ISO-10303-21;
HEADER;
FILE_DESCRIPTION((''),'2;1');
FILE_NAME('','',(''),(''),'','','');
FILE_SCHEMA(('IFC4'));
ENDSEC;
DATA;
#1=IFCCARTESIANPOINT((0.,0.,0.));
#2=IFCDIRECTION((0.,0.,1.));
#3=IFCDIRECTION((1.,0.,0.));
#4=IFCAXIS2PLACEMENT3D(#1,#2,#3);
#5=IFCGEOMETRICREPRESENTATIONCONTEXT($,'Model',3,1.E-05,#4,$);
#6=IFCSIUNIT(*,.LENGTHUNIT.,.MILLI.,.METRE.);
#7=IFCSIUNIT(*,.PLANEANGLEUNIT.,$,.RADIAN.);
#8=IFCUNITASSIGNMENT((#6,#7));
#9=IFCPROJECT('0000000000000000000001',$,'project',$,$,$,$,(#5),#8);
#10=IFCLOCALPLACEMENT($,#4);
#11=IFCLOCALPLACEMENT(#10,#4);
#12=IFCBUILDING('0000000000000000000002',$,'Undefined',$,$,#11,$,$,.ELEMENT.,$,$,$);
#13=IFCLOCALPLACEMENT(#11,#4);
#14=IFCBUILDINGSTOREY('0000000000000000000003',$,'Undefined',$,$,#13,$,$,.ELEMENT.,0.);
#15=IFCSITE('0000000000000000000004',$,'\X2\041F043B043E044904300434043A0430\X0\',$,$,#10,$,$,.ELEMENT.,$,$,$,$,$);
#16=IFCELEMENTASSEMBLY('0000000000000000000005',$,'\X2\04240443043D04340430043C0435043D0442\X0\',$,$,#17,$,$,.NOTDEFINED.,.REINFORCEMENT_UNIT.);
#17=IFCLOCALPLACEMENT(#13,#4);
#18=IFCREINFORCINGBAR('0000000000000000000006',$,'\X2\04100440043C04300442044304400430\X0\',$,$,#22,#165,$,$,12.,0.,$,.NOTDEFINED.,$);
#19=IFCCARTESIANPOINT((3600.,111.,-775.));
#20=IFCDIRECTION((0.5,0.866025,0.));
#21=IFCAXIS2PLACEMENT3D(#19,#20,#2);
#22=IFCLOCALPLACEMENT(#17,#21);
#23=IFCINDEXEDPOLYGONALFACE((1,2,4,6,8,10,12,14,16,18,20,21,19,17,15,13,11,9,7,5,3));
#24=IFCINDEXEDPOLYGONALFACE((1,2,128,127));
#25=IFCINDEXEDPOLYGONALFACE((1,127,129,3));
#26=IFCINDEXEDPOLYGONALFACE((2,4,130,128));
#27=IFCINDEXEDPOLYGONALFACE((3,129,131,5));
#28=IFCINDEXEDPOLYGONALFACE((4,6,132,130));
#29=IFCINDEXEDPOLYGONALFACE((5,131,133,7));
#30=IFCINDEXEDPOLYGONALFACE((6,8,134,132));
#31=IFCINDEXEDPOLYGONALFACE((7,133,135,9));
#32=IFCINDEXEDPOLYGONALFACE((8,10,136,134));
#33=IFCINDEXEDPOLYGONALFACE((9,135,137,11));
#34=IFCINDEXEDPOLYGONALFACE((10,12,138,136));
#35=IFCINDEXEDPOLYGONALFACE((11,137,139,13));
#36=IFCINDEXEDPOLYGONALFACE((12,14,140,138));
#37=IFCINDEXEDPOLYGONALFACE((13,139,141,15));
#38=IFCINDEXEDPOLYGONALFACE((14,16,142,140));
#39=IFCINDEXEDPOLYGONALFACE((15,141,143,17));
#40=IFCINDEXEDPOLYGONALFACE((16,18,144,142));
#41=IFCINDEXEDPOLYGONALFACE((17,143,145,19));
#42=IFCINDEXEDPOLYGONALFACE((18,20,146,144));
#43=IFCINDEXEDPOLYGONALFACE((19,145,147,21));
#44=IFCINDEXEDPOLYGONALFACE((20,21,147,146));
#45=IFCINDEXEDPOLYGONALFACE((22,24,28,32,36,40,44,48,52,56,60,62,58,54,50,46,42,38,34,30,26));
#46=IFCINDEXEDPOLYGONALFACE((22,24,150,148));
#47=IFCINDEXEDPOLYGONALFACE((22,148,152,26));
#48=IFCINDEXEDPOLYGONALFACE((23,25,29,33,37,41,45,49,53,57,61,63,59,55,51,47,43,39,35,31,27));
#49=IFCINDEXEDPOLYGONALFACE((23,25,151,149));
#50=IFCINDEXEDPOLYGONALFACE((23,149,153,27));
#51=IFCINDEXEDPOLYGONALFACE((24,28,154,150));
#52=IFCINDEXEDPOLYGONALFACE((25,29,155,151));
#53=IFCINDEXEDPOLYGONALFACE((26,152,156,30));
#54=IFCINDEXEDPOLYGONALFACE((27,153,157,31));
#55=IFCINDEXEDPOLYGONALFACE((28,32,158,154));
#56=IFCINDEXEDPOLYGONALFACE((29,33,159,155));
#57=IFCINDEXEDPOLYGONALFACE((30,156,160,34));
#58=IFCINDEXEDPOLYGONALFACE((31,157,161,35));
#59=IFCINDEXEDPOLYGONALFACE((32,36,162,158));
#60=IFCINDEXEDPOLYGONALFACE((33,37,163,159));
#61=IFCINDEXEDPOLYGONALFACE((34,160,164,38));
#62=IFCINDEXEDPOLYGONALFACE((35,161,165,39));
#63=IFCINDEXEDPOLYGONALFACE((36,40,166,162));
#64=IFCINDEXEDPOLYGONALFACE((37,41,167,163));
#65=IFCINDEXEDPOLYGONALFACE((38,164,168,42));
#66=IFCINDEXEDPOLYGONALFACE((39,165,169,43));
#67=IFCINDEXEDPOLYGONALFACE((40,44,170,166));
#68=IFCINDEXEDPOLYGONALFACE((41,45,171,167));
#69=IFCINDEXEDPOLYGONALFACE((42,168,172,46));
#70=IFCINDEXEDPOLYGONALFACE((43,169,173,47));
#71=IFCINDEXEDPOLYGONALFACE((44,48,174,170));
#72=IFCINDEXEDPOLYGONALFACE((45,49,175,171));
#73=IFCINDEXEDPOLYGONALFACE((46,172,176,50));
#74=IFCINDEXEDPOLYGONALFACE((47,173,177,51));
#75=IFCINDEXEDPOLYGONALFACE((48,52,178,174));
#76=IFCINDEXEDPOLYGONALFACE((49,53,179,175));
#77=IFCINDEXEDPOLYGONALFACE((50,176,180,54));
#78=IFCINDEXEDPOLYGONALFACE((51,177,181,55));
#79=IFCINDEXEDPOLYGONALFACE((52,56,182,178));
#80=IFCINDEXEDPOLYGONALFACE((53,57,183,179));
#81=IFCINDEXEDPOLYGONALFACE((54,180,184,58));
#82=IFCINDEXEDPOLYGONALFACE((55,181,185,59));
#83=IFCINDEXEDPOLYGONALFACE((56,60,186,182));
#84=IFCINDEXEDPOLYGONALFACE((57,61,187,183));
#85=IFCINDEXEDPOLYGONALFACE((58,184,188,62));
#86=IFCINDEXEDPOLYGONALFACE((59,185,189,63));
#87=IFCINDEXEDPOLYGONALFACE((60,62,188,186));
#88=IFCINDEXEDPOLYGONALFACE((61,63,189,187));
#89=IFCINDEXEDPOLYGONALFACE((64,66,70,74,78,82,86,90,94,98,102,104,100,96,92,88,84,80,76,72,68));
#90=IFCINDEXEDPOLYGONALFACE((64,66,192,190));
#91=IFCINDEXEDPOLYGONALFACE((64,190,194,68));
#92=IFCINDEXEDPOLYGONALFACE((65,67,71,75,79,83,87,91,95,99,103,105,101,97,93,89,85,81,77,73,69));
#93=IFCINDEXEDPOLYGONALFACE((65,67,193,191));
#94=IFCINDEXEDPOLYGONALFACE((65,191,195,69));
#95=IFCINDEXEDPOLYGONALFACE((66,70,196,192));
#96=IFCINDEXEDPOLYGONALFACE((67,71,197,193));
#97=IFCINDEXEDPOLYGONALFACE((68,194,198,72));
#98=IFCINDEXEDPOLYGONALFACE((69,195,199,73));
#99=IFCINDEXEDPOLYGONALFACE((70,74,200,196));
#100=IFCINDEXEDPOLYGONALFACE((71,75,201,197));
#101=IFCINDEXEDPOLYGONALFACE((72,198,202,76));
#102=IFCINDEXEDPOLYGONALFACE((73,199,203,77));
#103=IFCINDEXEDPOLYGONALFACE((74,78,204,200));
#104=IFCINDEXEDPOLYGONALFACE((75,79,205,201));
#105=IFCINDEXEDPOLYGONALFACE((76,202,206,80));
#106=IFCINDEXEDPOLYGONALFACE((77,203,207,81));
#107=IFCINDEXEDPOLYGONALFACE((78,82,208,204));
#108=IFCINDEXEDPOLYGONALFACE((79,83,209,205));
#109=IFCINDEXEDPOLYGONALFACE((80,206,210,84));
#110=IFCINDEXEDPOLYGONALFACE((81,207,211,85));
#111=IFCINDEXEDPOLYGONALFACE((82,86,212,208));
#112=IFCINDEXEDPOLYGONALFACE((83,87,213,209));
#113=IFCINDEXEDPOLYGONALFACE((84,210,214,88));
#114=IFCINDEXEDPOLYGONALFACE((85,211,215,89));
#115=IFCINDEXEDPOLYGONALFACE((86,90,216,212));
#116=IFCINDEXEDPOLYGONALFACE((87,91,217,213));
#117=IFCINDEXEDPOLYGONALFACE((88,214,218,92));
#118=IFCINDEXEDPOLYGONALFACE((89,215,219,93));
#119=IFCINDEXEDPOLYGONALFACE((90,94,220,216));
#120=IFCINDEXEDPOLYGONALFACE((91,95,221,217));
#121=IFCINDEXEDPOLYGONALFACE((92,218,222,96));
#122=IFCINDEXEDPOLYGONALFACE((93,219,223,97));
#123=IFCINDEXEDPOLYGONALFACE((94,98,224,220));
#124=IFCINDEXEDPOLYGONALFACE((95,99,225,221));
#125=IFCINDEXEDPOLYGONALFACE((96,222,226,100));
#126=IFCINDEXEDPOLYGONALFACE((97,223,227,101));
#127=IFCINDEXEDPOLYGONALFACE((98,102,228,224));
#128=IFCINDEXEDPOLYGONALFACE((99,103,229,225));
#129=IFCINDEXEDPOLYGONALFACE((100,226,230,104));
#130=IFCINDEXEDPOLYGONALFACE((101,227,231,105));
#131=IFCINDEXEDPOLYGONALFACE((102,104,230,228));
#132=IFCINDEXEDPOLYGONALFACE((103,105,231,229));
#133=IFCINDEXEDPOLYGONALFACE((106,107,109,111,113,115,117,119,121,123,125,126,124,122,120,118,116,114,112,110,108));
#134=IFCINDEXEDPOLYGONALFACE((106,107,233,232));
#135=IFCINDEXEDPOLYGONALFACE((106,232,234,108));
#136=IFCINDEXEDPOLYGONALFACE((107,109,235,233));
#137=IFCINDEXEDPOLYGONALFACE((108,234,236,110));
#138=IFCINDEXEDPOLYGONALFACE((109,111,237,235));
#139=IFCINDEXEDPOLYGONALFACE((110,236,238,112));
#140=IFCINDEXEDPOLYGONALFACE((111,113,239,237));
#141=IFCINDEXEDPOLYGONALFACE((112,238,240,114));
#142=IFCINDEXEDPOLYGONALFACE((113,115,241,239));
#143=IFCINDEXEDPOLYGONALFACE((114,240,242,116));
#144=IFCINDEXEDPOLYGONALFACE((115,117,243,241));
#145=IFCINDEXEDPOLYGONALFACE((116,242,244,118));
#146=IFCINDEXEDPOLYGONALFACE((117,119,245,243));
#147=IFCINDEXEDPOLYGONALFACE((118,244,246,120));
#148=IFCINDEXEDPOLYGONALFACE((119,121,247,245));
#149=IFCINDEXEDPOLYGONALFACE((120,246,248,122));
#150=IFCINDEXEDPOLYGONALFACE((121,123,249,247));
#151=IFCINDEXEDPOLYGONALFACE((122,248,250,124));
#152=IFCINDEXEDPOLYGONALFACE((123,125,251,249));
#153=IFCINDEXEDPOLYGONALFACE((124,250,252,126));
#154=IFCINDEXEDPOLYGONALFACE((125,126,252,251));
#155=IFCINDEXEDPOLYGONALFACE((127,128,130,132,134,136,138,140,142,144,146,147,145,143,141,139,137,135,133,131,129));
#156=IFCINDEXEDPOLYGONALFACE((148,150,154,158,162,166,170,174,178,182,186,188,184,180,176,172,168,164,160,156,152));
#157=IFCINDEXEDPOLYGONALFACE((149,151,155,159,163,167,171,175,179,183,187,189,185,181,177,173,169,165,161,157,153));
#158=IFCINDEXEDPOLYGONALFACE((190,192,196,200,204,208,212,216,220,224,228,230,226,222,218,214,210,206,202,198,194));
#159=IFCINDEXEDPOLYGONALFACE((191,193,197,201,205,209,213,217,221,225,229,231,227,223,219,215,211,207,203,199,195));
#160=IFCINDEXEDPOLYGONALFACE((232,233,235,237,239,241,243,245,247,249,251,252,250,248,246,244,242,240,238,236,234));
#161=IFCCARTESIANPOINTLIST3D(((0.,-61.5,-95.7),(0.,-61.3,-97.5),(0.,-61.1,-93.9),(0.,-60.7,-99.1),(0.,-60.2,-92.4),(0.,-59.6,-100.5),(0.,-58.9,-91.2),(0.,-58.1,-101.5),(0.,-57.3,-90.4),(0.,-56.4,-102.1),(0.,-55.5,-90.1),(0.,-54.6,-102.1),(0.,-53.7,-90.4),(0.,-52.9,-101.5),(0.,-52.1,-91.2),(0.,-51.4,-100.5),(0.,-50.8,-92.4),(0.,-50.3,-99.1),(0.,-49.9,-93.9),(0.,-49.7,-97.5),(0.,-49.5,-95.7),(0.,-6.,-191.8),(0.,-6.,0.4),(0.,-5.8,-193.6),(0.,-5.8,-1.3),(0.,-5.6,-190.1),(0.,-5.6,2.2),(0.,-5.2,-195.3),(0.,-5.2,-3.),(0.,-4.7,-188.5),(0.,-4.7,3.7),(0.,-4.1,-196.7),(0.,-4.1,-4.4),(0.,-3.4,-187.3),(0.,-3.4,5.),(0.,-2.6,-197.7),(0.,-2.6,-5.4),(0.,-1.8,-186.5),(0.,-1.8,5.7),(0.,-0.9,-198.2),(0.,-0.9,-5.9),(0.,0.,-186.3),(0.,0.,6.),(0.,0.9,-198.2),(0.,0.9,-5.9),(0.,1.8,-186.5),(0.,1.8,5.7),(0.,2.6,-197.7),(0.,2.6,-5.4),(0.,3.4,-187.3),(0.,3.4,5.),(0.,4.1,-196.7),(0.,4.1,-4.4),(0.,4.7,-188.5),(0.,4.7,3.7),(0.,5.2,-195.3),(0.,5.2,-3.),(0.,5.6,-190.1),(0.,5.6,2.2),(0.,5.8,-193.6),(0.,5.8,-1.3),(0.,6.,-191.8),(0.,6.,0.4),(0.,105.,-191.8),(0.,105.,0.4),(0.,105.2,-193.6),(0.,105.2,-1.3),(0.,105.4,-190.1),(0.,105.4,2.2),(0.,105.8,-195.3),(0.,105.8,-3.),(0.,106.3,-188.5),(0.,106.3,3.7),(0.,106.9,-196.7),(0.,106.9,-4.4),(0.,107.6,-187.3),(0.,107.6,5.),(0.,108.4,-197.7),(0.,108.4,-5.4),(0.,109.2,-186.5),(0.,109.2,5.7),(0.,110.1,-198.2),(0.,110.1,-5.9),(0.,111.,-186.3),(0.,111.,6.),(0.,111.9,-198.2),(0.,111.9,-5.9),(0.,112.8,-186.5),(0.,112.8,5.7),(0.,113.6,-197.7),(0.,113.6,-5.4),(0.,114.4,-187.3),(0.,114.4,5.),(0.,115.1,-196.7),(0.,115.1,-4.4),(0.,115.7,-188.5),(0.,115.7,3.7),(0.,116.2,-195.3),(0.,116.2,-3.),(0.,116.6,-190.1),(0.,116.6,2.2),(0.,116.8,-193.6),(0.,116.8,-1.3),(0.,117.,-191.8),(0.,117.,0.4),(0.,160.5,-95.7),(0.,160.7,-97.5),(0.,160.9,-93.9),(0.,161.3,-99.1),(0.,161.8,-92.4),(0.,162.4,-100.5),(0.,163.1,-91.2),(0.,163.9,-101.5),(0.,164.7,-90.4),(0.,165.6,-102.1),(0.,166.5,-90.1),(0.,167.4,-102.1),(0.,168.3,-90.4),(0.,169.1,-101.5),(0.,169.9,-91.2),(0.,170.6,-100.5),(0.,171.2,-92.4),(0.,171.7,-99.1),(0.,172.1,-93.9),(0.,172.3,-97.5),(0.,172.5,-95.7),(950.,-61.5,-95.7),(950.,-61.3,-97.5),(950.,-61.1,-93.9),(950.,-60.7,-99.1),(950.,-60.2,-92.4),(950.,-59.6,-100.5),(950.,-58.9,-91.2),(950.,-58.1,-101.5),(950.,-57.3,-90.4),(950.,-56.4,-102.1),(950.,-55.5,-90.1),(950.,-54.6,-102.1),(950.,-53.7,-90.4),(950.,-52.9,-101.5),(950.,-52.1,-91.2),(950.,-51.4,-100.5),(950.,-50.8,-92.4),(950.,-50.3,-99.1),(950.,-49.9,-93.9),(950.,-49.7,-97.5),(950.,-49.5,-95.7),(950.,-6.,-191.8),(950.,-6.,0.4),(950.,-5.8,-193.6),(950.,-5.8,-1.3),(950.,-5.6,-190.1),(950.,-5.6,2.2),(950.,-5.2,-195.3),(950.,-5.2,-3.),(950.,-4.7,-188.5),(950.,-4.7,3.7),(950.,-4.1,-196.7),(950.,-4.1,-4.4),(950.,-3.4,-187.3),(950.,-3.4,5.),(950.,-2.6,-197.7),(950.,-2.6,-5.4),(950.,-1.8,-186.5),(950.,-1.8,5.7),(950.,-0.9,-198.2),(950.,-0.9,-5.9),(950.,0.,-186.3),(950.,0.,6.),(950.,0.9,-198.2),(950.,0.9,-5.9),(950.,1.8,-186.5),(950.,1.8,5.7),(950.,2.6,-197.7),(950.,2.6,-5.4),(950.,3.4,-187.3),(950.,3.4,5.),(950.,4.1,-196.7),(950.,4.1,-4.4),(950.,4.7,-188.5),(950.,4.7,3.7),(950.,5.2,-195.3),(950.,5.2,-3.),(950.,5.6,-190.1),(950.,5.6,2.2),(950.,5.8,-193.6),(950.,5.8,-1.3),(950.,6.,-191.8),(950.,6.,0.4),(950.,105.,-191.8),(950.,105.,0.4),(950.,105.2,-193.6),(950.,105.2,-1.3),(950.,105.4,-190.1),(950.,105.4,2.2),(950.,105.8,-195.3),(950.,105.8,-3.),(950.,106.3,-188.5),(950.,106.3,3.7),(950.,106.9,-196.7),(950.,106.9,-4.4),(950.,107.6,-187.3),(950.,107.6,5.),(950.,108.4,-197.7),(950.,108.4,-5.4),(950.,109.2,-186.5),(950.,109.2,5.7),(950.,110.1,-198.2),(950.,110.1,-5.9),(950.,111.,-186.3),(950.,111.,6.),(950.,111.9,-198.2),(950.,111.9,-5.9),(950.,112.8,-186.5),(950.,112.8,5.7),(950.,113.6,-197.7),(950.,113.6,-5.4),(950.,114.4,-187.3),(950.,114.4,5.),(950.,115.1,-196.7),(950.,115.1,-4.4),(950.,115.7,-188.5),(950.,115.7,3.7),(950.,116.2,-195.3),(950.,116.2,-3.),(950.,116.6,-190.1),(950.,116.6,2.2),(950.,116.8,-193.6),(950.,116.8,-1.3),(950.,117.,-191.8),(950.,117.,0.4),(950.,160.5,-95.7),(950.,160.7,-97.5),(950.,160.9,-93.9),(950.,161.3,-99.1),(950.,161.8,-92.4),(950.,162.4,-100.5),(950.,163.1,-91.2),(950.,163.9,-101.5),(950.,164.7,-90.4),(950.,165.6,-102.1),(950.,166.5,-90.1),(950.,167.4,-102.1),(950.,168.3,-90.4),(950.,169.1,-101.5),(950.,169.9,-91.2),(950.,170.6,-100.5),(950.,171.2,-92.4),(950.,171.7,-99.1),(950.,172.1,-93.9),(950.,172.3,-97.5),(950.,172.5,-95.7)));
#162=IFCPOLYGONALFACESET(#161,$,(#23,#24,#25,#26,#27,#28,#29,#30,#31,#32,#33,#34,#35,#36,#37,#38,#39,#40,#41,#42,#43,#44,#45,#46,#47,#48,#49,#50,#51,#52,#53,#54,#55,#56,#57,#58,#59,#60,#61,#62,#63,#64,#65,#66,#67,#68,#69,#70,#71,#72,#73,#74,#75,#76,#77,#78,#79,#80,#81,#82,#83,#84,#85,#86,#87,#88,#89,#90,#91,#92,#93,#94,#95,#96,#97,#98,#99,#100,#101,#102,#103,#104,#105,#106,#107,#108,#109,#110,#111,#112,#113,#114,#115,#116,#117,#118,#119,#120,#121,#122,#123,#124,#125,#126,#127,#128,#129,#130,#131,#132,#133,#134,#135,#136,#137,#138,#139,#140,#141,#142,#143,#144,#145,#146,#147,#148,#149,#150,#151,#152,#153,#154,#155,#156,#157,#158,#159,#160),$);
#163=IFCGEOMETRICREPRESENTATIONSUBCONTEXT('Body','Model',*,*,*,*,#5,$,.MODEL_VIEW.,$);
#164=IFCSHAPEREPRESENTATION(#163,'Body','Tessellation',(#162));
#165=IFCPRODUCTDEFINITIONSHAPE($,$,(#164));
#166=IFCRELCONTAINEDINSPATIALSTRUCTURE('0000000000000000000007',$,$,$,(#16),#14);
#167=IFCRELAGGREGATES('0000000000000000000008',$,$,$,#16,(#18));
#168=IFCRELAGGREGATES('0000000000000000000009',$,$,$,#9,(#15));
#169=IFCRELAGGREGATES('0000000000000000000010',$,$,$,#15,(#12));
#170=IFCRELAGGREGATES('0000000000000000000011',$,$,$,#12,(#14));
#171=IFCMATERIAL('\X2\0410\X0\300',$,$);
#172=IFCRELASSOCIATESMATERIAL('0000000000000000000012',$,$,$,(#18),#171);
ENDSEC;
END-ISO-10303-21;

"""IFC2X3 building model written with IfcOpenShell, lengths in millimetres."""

from ifc_helpers import new_model, entity, si_unit, frame, origin_with_axes, place, context, subcontext, project, spatial, source, transform, mapped, material, element, aggregate, save


model = new_model("IFC2X3")

# Units and contexts
model_context = context("Model", 3, precision=1e-05, world=origin_with_axes())
body_context = subcontext(model_context, "Body", "Model", "MODEL_VIEW")
ifc_project = project(units=[si_unit("LENGTHUNIT", "METRE", prefix="MILLI"), si_unit("PLANEANGLEUNIT", "RADIAN")], contexts=[model_context])

# Site, building, storey
site_placement = place(None, origin_with_axes())
site = spatial("IfcSite", under=ifc_project, at=site_placement, Name="Площадка", CompositionType="ELEMENT")
building_placement = place(site_placement, origin_with_axes())
building = spatial("IfcBuilding", under=site, at=building_placement, Name="Undefined", CompositionType="ELEMENT")
storey_placement = place(building_placement, origin_with_axes())
storey = spatial("IfcBuildingStorey", under=building, at=storey_placement, Name="Undefined", CompositionType="ELEMENT", Elevation=0.0)

# Element assembly
assembly_1_placement = place(storey_placement, origin_with_axes())
assembly_1 = element("IfcElementAssembly", 1, at=assembly_1_placement, inside=storey, Name="Фундамент", AssemblyPlace="NOTDEFINED", PredefinedType="REINFORCEMENT_UNIT")

# Reinforcing bar
ifc_material_1 = material(Name="А300")
shared_shape_1 = source(origin_with_axes(), body_context, "Body", "AdvancedSweptSolid", [
    entity("IfcSweptDiskSolid", entity("IfcTrimmedCurve", entity("IfcLine", entity("IfcCartesianPoint", [0.0, 0.0, 0.0]), entity("IfcVector", entity("IfcDirection", [1.0, 0.0, 0.0]), 1.0)), [entity("IfcParameterValue", 0.0)], [entity("IfcParameterValue", 950.0)], True, "PARAMETER"), 6.0, None, 0.0, 950.0),
])
shared_shape_2 = source(origin_with_axes(), body_context, "Body", "AdvancedSweptSolid", [
    entity("IfcSweptDiskSolid", entity("IfcTrimmedCurve", entity("IfcLine", entity("IfcCartesianPoint", [0.0, 0.0, 0.0]), entity("IfcVector", entity("IfcDirection", [1.0, 0.0, 0.0]), 1.0)), [entity("IfcParameterValue", 0.0)], [entity("IfcParameterValue", 950.0)], True, "PARAMETER"), 6.0, None, 0.0, 950.0),
])
shared_shape_3 = source(origin_with_axes(), body_context, "Body", "AdvancedSweptSolid", [
    entity("IfcSweptDiskSolid", entity("IfcTrimmedCurve", entity("IfcLine", entity("IfcCartesianPoint", [0.0, 0.0, 0.0]), entity("IfcVector", entity("IfcDirection", [1.0, 0.0, 0.0]), 1.0)), [entity("IfcParameterValue", 0.0)], [entity("IfcParameterValue", 950.0)], True, "PARAMETER"), 6.0, None, 0.0, 950.0),
])
shared_shape_4 = source(origin_with_axes(), body_context, "Body", "AdvancedSweptSolid", [
    entity("IfcSweptDiskSolid", entity("IfcTrimmedCurve", entity("IfcLine", entity("IfcCartesianPoint", [0.0, 0.0, 0.0]), entity("IfcVector", entity("IfcDirection", [1.0, 0.0, 0.0]), 1.0)), [entity("IfcParameterValue", 0.0)], [entity("IfcParameterValue", 950.0)], True, "PARAMETER"), 6.0, None, 0.0, 950.0),
])
shared_shape_5 = source(origin_with_axes(), body_context, "Body", "AdvancedSweptSolid", [
    entity("IfcSweptDiskSolid", entity("IfcTrimmedCurve", entity("IfcLine", entity("IfcCartesianPoint", [0.0, 0.0, 0.0]), entity("IfcVector", entity("IfcDirection", [1.0, 0.0, 0.0]), 1.0)), [entity("IfcParameterValue", 0.0)], [entity("IfcParameterValue", 950.0)], True, "PARAMETER"), 6.0, None, 0.0, 950.0),
])
shared_shape_6 = source(origin_with_axes(), body_context, "Body", "AdvancedSweptSolid", [
    entity("IfcSweptDiskSolid", entity("IfcTrimmedCurve", entity("IfcLine", entity("IfcCartesianPoint", [0.0, 0.0, 0.0]), entity("IfcVector", entity("IfcDirection", [1.0, 0.0, 0.0]), 1.0)), [entity("IfcParameterValue", 0.0)], [entity("IfcParameterValue", 950.0)], True, "PARAMETER"), 6.0, None, 0.0, 950.0),
])
reinforcing_bar_1_placement = place(assembly_1_placement, frame((3600.0, 111.0, -775.0), z_axis=(0.5, 0.866025, 0.0), x_axis=(0.0, 0.0, 1.0)))
reinforcing_bar_1 = element("IfcReinforcingBar", 2, at=reinforcing_bar_1_placement, material=ifc_material_1, Name="Арматура", BarRole="NOTDEFINED", CrossSectionArea=0.0, NominalDiameter=12.0, context=body_context, shape_type="MappedRepresentation", body=[
    mapped(shared_shape_1, transform((0.0, 0.0, 0.0))),
    mapped(shared_shape_2, transform((0.0, -55.5, -96.1))),
    mapped(shared_shape_3, transform((0.0, 0.0, -192.3))),
    mapped(shared_shape_4, transform((0.0, 111.0, -192.3))),
    mapped(shared_shape_5, transform((0.0, 166.5, -96.1))),
    mapped(shared_shape_6, transform((0.0, 111.0, 0.0))),
])
aggregate(assembly_1, [reinforcing_bar_1])

save(model, "model.ifc")
